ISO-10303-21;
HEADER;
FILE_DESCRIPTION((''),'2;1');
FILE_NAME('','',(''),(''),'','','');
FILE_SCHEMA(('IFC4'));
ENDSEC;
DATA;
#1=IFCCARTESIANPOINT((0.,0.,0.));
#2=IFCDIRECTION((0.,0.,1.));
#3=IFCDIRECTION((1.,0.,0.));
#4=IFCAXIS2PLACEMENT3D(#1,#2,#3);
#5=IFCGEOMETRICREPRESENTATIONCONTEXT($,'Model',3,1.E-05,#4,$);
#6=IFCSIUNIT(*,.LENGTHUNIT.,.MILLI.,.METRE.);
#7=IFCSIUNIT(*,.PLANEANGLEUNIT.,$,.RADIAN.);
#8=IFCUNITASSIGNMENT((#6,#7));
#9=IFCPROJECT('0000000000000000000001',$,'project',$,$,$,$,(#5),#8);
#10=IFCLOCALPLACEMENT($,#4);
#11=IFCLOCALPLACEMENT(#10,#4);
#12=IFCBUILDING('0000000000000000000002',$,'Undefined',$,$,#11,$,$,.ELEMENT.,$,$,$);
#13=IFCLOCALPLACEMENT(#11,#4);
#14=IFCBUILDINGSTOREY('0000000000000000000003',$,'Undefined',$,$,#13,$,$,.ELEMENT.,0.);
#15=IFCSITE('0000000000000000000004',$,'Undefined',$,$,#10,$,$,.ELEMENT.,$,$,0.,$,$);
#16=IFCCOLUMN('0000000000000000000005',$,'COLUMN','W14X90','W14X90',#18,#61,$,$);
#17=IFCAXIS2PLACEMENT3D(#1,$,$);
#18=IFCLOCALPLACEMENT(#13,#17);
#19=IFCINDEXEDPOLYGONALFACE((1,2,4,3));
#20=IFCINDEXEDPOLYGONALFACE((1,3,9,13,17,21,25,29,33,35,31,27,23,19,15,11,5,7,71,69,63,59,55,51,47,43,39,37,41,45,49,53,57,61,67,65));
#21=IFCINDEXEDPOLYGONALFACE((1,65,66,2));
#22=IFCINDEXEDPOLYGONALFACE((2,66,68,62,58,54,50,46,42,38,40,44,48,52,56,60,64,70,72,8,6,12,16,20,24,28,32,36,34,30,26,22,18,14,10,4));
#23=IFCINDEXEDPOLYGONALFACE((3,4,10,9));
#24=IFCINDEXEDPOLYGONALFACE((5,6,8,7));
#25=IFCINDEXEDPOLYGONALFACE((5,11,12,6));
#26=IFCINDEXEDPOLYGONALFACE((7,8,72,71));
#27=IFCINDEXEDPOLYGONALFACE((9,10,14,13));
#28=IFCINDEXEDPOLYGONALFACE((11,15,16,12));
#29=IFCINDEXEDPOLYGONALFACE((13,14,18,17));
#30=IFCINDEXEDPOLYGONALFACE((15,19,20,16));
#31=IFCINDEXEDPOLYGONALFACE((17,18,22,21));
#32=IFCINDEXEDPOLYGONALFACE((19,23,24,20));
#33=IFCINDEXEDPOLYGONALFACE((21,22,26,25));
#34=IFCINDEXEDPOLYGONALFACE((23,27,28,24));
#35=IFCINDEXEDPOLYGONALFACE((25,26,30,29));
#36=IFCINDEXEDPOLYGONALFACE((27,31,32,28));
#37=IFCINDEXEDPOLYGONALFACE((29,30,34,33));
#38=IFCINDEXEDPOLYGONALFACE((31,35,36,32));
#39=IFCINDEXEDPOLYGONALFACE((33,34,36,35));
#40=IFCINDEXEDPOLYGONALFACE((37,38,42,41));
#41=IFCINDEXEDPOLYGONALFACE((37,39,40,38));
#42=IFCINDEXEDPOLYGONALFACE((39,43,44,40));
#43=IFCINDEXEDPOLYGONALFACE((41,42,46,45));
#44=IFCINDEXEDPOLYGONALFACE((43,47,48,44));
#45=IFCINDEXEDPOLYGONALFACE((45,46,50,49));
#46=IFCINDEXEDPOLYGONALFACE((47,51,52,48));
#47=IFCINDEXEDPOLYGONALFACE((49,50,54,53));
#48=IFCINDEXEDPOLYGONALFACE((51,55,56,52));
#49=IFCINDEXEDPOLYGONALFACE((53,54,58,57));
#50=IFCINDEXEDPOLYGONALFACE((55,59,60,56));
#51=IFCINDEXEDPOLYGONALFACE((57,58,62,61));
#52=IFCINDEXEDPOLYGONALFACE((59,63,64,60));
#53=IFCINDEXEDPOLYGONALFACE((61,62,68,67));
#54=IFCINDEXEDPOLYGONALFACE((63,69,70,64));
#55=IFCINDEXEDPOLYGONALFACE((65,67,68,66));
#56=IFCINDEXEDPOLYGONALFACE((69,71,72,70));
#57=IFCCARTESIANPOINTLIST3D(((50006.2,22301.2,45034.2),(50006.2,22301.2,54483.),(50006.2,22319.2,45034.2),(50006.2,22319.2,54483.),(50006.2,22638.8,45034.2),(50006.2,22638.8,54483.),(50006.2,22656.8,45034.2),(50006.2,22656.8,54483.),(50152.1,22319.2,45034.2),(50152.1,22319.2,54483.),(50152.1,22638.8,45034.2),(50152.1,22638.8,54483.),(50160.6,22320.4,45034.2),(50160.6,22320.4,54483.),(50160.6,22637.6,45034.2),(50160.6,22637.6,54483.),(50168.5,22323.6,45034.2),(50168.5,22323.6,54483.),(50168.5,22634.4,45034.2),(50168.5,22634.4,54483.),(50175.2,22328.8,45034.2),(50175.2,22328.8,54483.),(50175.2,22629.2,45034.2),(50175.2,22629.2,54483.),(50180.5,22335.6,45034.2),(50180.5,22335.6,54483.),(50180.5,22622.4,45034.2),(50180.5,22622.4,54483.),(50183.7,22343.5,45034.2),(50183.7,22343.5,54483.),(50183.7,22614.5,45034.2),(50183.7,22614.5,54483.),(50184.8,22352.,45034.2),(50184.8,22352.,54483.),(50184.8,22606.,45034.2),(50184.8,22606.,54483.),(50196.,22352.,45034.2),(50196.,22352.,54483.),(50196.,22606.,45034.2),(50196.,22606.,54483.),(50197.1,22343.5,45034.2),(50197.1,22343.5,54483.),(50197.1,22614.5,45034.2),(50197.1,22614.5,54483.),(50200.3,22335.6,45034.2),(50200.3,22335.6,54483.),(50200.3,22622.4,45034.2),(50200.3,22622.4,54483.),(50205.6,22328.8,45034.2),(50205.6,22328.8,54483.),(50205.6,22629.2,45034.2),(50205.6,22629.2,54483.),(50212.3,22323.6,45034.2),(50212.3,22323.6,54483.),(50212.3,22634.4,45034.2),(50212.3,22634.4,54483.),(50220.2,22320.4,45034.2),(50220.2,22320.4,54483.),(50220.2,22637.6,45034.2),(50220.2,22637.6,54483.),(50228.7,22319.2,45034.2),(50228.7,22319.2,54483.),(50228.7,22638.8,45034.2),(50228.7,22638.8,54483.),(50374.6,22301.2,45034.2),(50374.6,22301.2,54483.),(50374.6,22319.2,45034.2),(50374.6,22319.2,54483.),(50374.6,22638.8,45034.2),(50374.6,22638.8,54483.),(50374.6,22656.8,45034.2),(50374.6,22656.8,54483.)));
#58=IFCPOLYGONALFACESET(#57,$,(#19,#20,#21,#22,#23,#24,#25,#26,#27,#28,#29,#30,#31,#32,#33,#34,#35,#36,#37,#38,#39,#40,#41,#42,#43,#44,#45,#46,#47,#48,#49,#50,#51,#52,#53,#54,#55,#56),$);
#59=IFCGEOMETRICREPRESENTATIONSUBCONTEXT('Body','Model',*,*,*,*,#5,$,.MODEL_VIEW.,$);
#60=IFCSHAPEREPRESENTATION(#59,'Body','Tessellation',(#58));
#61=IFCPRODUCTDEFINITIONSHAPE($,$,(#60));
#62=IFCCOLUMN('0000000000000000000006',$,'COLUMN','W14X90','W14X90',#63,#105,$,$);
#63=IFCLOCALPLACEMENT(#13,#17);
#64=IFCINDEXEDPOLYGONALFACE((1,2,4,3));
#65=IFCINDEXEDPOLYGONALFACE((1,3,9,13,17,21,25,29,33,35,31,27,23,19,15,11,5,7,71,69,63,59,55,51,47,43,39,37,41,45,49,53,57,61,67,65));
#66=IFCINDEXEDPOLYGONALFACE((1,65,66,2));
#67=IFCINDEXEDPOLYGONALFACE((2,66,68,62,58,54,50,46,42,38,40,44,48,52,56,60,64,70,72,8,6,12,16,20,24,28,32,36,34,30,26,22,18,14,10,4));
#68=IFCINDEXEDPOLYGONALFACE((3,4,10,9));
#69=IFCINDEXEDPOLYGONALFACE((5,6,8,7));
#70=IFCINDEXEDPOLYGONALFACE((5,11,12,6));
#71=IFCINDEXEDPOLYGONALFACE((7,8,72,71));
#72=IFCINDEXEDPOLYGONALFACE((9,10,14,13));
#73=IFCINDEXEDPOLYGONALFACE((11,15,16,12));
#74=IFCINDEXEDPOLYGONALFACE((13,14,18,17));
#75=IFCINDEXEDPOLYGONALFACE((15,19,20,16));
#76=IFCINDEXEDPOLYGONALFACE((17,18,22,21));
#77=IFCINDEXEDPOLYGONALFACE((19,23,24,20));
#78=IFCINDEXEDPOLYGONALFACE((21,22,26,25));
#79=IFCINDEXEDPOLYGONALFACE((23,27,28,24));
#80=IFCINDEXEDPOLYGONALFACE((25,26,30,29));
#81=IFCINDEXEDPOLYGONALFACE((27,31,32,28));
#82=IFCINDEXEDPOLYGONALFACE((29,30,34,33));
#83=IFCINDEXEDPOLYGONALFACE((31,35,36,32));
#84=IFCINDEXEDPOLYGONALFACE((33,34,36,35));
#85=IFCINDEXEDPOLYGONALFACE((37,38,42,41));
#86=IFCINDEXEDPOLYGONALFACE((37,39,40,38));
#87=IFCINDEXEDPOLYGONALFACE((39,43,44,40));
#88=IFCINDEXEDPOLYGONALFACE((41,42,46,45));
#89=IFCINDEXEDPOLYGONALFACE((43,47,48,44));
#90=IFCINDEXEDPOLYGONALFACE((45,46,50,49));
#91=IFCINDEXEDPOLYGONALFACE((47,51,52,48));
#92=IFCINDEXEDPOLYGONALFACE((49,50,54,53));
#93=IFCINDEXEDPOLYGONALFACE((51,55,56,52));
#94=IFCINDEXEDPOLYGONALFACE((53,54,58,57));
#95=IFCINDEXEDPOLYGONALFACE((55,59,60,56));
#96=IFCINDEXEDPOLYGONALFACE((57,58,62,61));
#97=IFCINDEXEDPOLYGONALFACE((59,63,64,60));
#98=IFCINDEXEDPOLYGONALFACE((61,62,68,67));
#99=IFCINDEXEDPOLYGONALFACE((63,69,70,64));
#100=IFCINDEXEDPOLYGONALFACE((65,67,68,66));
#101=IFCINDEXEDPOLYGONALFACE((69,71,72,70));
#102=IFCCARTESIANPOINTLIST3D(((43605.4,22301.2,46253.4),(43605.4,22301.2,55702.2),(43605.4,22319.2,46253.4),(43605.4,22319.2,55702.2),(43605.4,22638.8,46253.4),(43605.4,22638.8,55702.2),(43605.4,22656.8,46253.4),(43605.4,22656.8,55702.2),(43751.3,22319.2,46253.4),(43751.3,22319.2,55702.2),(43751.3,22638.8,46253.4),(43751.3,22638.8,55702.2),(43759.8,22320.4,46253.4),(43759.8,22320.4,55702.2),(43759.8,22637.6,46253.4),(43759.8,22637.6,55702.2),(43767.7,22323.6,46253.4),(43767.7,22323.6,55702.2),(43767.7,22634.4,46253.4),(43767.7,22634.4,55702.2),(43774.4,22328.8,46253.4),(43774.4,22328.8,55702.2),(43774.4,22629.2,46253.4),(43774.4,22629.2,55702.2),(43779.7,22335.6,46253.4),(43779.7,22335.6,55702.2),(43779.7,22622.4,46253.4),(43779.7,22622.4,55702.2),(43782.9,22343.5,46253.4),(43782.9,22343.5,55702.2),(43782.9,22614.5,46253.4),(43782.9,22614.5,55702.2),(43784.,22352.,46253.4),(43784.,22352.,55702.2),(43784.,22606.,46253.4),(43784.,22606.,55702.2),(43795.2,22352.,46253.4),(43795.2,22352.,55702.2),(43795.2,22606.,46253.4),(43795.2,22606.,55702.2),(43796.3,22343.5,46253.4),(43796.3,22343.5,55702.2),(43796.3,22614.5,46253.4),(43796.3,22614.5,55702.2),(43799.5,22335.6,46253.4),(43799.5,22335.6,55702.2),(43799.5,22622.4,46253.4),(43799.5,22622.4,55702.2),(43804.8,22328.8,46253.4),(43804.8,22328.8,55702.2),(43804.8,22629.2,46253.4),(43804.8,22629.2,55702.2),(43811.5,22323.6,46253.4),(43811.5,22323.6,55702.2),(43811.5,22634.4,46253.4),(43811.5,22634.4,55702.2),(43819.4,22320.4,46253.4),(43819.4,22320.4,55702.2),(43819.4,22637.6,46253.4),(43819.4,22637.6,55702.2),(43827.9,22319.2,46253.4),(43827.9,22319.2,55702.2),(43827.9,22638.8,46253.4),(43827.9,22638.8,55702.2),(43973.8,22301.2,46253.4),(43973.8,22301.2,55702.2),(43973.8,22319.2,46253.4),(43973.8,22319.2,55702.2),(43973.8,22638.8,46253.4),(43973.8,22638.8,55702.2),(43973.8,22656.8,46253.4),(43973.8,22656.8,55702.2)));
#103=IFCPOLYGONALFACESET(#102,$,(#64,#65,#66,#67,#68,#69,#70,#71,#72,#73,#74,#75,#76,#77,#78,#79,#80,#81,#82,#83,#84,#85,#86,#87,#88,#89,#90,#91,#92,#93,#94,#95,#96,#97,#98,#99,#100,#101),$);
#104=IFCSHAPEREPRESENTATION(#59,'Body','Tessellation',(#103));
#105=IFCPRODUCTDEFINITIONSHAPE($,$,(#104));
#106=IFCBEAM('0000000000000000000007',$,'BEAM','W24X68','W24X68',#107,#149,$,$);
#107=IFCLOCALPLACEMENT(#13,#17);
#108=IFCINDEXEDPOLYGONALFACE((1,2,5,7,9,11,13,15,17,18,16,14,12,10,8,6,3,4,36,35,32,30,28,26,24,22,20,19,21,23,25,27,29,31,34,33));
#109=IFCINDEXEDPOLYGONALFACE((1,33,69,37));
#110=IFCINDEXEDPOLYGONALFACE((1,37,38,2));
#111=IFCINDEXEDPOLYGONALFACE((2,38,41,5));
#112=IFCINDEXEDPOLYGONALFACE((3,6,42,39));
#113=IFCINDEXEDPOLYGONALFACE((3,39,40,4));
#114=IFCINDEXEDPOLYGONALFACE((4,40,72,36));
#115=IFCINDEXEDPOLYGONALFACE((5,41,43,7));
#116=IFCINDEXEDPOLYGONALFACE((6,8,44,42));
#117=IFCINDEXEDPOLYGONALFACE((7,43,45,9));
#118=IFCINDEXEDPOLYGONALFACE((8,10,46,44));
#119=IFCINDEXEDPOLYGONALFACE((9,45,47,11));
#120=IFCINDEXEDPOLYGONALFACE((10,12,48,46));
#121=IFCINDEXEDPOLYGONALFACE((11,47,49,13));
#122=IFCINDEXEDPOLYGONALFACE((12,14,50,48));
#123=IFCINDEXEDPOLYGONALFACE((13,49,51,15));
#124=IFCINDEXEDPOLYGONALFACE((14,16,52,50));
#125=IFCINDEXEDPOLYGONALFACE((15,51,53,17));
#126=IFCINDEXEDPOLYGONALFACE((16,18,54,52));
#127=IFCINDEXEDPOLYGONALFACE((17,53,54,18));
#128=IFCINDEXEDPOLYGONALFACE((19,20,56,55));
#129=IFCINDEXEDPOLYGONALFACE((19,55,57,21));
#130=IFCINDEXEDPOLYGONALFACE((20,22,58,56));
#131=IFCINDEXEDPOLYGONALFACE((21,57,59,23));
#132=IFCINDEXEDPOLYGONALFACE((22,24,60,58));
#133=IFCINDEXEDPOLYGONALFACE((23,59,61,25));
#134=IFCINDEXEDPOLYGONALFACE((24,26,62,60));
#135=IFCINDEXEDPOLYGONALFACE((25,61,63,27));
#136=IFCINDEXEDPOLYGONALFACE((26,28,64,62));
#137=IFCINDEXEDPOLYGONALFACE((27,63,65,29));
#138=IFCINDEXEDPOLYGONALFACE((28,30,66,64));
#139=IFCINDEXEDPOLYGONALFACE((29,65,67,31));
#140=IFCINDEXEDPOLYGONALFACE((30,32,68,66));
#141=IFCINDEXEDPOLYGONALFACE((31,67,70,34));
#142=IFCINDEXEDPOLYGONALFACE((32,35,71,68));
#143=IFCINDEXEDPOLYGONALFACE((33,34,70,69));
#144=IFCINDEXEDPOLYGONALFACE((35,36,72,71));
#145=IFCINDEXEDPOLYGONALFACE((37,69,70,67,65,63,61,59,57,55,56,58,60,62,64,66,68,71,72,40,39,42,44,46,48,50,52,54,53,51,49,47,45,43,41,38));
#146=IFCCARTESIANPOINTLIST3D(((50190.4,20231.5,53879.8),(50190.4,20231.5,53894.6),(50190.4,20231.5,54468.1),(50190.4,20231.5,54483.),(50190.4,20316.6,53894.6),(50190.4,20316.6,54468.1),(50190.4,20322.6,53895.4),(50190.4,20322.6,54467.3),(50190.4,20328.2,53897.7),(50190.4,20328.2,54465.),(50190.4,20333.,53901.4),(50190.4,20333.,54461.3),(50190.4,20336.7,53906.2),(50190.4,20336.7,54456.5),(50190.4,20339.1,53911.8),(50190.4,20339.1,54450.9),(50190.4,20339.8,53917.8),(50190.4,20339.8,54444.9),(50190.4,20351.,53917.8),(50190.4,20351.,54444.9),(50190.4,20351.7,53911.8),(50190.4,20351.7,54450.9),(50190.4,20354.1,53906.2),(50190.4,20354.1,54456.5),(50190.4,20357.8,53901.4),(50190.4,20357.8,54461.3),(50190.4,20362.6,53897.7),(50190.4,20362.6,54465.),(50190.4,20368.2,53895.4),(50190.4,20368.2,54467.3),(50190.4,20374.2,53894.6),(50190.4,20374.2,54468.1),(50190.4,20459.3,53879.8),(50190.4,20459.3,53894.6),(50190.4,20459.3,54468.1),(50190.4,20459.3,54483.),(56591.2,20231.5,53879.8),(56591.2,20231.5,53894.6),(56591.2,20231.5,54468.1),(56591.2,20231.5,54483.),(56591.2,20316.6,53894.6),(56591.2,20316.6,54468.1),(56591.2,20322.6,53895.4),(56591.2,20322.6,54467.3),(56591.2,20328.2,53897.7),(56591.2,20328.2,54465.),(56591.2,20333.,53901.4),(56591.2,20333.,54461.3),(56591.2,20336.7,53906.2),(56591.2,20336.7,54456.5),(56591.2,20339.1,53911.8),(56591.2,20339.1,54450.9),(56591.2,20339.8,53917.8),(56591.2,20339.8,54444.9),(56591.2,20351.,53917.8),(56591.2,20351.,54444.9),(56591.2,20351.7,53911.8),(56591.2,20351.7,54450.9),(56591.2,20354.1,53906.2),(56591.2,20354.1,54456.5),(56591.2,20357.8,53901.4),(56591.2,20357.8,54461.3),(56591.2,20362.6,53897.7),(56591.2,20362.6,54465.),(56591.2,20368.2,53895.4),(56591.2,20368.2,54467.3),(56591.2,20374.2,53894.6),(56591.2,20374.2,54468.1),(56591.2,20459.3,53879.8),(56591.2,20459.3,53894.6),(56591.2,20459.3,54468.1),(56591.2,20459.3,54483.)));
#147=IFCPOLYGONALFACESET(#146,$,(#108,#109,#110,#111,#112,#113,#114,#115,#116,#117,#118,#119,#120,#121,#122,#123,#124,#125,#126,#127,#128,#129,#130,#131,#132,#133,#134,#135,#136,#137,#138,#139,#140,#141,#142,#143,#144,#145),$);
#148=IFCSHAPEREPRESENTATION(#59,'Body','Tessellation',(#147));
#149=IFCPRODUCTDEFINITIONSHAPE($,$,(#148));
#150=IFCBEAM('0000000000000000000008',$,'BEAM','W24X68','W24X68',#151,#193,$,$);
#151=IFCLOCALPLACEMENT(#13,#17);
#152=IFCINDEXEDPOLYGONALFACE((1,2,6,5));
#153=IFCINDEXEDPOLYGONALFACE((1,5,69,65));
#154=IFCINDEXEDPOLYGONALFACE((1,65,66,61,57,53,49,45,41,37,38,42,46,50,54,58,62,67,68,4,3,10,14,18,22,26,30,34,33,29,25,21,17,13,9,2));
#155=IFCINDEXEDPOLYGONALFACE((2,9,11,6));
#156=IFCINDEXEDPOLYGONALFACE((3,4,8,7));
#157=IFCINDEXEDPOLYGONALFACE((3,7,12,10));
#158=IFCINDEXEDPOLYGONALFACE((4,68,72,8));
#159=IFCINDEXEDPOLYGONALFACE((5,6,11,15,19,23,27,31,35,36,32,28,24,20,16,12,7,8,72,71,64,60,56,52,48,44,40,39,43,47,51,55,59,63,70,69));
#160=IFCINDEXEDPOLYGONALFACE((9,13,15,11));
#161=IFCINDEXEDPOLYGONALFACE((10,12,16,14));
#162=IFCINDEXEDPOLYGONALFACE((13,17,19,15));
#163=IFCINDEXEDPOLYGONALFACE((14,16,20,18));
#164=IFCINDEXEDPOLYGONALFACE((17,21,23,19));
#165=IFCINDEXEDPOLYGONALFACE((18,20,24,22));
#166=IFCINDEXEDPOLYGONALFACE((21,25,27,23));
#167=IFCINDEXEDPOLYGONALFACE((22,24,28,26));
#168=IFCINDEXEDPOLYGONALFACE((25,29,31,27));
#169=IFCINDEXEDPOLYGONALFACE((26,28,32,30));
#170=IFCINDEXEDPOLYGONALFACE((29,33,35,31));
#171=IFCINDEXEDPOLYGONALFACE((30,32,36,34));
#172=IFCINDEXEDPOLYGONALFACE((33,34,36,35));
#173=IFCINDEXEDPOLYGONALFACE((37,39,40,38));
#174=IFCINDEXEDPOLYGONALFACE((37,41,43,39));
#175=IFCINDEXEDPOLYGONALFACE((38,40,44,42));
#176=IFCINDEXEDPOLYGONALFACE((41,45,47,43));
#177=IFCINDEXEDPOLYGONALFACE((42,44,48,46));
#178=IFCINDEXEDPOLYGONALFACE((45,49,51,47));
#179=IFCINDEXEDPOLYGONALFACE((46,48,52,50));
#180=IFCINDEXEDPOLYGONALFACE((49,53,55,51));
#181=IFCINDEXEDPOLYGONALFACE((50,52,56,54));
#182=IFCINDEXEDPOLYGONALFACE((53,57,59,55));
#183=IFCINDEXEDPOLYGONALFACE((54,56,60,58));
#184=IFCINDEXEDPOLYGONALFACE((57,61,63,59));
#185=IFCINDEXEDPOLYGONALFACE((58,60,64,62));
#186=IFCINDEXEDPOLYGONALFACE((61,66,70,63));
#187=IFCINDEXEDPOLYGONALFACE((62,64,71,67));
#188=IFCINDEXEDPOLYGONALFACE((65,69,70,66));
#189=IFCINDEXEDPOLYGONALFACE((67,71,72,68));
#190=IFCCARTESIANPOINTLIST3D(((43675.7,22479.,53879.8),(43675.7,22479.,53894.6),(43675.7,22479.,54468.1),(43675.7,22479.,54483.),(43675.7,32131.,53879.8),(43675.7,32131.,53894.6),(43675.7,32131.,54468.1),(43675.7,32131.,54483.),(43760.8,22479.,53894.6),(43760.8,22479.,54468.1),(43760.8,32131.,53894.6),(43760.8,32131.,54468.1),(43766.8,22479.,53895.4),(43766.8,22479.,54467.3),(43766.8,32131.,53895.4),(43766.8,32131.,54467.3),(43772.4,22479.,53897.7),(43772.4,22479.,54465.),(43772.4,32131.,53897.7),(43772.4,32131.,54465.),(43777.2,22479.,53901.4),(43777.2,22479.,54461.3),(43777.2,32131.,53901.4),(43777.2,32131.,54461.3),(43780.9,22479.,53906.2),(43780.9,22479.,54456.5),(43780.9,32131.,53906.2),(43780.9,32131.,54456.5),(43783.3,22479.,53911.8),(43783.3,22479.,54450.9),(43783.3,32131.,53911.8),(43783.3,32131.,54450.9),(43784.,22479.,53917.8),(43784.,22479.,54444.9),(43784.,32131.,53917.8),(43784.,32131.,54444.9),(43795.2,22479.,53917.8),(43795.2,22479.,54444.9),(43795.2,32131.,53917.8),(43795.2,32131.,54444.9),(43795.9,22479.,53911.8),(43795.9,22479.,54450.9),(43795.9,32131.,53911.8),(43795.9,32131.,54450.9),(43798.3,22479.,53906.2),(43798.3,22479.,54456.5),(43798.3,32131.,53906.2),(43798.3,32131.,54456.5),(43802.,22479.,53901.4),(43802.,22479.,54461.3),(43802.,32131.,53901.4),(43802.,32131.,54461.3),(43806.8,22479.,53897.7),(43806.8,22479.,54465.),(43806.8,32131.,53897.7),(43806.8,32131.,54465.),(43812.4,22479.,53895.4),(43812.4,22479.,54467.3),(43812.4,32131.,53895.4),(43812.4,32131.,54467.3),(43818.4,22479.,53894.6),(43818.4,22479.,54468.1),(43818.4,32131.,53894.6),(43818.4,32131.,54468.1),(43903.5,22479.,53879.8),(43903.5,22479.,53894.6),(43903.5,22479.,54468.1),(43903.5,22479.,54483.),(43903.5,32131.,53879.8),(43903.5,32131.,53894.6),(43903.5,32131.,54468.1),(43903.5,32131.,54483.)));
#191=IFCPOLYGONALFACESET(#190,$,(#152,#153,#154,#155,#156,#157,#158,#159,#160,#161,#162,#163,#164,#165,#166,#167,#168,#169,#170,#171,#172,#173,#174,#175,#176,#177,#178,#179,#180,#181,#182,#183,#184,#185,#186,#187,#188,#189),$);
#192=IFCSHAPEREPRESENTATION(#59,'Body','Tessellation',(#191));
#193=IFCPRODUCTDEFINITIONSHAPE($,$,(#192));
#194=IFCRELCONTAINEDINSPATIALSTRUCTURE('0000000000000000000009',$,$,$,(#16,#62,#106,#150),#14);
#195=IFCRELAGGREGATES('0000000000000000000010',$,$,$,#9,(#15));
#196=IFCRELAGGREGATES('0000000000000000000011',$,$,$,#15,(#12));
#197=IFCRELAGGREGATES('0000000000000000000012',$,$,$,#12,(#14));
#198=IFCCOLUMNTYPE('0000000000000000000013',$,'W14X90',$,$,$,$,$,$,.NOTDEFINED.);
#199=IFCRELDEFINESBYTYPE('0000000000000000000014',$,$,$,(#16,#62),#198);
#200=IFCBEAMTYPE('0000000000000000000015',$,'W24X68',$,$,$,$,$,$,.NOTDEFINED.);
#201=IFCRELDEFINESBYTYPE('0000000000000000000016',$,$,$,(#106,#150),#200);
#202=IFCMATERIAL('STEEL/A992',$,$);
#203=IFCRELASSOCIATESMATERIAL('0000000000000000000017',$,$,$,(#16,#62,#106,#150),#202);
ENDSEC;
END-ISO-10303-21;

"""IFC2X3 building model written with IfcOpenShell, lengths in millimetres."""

from ifc_helpers import new_model, si_unit, frame, origin_with_axes, origin_2d_with_axis, place, context, subcontext, project, spatial, i_section, extrude, material, type_object, element, save


model = new_model("IFC2X3")

# Units and contexts
model_context = context("Model", 3, precision=1e-05, world=origin_with_axes())
body_context = subcontext(model_context, "Body", "Model", "MODEL_VIEW")
ifc_project = project(units=[si_unit("LENGTHUNIT", "METRE", prefix="MILLI"), si_unit("PLANEANGLEUNIT", "RADIAN")], contexts=[model_context])

# Site, building, storey
site_placement = place(None, origin_with_axes())
site = spatial("IfcSite", under=ifc_project, at=site_placement, Name="Undefined", CompositionType="ELEMENT", RefElevation=0.0)
building_placement = place(site_placement, origin_with_axes())
building = spatial("IfcBuilding", under=site, at=building_placement, Name="Undefined", CompositionType="ELEMENT")
storey_placement = place(building_placement, origin_with_axes())
storey = spatial("IfcBuildingStorey", under=building, at=storey_placement, Name="Undefined", CompositionType="ELEMENT", Elevation=0.0)

# Columns
ifc_material = material(Name="STEEL/A992")
column_type = type_object("IfcColumnType", Name="W14X90", PredefinedType="NOTDEFINED")
for number, where, z_axis, x_axis, name in (
    (1, (50190.4, 22479.0, 45034.2), (0.0, 0.0, 1.0), (1.0, 0.0, 0.0), "COLUMN"),
    (2, (43789.6, 22479.0, 46253.4), (0.0, 0.0, 1.0), (1.0, 0.0, 0.0), "COLUMN"),
):
    element("IfcColumn", number, at=place(storey_placement, frame(where, z_axis=z_axis, x_axis=x_axis)), inside=storey, type_object=column_type, material=ifc_material, Name=name, Description="W14X90", ObjectType="W14X90", context=body_context, shape_type="SweptSolid", body=[
        extrude(i_section(OverallWidth=368.3, OverallDepth=355.6, WebThickness=11.1, FlangeThickness=18.0, FilletRadius=32.8, at=origin_2d_with_axis()), frame((0.0, 0.0, 9448.8), z_axis=(0.0, 0.0, -1.0), x_axis=(-1.0, 0.0, 0.0)), (0.0, 0.0, 1.0), 9448.8),
    ])

# Beams
beam_type = type_object("IfcBeamType", Name="W24X68", PredefinedType="NOTDEFINED")
beam_1_placement = place(storey_placement, frame((50190.4, 20345.4, 54181.4), z_axis=(0.0, 0.0, 1.0), x_axis=(1.0, 0.0, 0.0)))
element("IfcBeam", 3, at=beam_1_placement, inside=storey, type_object=beam_type, material=ifc_material, Name="BEAM", Description="W24X68", ObjectType="W24X68", context=body_context, shape_type="SweptSolid", body=[
    extrude(i_section(OverallWidth=227.8, OverallDepth=603.2, WebThickness=11.1, FlangeThickness=14.9, FilletRadius=23.2, at=origin_2d_with_axis()), frame((6400.8, 0.0, 0.0), z_axis=(-1.0, 0.0, 0.0), x_axis=(0.0, -1.0, 0.0)), (0.0, 0.0, 1.0), 6400.8),
])
for number, where, z_axis, x_axis, name in (
    (4, (43789.6, 22479.0, 54181.4), (0.0, 0.0, 1.0), (0.0, 1.0, 0.0), "BEAM"),
):
    element("IfcBeam", number, at=place(storey_placement, frame(where, z_axis=z_axis, x_axis=x_axis)), inside=storey, type_object=beam_type, material=ifc_material, Name=name, Description="W24X68", ObjectType="W24X68", context=body_context, shape_type="SweptSolid", body=[
        extrude(i_section(OverallWidth=227.8, OverallDepth=603.2, WebThickness=11.1, FlangeThickness=14.9, FilletRadius=23.2, at=origin_2d_with_axis()), frame((9652.0, 0.0, 0.0), z_axis=(-1.0, 0.0, 0.0), x_axis=(0.0, -1.0, 0.0)), (0.0, 0.0, 1.0), 9652.0),
    ])

save(model, "model.ifc")
